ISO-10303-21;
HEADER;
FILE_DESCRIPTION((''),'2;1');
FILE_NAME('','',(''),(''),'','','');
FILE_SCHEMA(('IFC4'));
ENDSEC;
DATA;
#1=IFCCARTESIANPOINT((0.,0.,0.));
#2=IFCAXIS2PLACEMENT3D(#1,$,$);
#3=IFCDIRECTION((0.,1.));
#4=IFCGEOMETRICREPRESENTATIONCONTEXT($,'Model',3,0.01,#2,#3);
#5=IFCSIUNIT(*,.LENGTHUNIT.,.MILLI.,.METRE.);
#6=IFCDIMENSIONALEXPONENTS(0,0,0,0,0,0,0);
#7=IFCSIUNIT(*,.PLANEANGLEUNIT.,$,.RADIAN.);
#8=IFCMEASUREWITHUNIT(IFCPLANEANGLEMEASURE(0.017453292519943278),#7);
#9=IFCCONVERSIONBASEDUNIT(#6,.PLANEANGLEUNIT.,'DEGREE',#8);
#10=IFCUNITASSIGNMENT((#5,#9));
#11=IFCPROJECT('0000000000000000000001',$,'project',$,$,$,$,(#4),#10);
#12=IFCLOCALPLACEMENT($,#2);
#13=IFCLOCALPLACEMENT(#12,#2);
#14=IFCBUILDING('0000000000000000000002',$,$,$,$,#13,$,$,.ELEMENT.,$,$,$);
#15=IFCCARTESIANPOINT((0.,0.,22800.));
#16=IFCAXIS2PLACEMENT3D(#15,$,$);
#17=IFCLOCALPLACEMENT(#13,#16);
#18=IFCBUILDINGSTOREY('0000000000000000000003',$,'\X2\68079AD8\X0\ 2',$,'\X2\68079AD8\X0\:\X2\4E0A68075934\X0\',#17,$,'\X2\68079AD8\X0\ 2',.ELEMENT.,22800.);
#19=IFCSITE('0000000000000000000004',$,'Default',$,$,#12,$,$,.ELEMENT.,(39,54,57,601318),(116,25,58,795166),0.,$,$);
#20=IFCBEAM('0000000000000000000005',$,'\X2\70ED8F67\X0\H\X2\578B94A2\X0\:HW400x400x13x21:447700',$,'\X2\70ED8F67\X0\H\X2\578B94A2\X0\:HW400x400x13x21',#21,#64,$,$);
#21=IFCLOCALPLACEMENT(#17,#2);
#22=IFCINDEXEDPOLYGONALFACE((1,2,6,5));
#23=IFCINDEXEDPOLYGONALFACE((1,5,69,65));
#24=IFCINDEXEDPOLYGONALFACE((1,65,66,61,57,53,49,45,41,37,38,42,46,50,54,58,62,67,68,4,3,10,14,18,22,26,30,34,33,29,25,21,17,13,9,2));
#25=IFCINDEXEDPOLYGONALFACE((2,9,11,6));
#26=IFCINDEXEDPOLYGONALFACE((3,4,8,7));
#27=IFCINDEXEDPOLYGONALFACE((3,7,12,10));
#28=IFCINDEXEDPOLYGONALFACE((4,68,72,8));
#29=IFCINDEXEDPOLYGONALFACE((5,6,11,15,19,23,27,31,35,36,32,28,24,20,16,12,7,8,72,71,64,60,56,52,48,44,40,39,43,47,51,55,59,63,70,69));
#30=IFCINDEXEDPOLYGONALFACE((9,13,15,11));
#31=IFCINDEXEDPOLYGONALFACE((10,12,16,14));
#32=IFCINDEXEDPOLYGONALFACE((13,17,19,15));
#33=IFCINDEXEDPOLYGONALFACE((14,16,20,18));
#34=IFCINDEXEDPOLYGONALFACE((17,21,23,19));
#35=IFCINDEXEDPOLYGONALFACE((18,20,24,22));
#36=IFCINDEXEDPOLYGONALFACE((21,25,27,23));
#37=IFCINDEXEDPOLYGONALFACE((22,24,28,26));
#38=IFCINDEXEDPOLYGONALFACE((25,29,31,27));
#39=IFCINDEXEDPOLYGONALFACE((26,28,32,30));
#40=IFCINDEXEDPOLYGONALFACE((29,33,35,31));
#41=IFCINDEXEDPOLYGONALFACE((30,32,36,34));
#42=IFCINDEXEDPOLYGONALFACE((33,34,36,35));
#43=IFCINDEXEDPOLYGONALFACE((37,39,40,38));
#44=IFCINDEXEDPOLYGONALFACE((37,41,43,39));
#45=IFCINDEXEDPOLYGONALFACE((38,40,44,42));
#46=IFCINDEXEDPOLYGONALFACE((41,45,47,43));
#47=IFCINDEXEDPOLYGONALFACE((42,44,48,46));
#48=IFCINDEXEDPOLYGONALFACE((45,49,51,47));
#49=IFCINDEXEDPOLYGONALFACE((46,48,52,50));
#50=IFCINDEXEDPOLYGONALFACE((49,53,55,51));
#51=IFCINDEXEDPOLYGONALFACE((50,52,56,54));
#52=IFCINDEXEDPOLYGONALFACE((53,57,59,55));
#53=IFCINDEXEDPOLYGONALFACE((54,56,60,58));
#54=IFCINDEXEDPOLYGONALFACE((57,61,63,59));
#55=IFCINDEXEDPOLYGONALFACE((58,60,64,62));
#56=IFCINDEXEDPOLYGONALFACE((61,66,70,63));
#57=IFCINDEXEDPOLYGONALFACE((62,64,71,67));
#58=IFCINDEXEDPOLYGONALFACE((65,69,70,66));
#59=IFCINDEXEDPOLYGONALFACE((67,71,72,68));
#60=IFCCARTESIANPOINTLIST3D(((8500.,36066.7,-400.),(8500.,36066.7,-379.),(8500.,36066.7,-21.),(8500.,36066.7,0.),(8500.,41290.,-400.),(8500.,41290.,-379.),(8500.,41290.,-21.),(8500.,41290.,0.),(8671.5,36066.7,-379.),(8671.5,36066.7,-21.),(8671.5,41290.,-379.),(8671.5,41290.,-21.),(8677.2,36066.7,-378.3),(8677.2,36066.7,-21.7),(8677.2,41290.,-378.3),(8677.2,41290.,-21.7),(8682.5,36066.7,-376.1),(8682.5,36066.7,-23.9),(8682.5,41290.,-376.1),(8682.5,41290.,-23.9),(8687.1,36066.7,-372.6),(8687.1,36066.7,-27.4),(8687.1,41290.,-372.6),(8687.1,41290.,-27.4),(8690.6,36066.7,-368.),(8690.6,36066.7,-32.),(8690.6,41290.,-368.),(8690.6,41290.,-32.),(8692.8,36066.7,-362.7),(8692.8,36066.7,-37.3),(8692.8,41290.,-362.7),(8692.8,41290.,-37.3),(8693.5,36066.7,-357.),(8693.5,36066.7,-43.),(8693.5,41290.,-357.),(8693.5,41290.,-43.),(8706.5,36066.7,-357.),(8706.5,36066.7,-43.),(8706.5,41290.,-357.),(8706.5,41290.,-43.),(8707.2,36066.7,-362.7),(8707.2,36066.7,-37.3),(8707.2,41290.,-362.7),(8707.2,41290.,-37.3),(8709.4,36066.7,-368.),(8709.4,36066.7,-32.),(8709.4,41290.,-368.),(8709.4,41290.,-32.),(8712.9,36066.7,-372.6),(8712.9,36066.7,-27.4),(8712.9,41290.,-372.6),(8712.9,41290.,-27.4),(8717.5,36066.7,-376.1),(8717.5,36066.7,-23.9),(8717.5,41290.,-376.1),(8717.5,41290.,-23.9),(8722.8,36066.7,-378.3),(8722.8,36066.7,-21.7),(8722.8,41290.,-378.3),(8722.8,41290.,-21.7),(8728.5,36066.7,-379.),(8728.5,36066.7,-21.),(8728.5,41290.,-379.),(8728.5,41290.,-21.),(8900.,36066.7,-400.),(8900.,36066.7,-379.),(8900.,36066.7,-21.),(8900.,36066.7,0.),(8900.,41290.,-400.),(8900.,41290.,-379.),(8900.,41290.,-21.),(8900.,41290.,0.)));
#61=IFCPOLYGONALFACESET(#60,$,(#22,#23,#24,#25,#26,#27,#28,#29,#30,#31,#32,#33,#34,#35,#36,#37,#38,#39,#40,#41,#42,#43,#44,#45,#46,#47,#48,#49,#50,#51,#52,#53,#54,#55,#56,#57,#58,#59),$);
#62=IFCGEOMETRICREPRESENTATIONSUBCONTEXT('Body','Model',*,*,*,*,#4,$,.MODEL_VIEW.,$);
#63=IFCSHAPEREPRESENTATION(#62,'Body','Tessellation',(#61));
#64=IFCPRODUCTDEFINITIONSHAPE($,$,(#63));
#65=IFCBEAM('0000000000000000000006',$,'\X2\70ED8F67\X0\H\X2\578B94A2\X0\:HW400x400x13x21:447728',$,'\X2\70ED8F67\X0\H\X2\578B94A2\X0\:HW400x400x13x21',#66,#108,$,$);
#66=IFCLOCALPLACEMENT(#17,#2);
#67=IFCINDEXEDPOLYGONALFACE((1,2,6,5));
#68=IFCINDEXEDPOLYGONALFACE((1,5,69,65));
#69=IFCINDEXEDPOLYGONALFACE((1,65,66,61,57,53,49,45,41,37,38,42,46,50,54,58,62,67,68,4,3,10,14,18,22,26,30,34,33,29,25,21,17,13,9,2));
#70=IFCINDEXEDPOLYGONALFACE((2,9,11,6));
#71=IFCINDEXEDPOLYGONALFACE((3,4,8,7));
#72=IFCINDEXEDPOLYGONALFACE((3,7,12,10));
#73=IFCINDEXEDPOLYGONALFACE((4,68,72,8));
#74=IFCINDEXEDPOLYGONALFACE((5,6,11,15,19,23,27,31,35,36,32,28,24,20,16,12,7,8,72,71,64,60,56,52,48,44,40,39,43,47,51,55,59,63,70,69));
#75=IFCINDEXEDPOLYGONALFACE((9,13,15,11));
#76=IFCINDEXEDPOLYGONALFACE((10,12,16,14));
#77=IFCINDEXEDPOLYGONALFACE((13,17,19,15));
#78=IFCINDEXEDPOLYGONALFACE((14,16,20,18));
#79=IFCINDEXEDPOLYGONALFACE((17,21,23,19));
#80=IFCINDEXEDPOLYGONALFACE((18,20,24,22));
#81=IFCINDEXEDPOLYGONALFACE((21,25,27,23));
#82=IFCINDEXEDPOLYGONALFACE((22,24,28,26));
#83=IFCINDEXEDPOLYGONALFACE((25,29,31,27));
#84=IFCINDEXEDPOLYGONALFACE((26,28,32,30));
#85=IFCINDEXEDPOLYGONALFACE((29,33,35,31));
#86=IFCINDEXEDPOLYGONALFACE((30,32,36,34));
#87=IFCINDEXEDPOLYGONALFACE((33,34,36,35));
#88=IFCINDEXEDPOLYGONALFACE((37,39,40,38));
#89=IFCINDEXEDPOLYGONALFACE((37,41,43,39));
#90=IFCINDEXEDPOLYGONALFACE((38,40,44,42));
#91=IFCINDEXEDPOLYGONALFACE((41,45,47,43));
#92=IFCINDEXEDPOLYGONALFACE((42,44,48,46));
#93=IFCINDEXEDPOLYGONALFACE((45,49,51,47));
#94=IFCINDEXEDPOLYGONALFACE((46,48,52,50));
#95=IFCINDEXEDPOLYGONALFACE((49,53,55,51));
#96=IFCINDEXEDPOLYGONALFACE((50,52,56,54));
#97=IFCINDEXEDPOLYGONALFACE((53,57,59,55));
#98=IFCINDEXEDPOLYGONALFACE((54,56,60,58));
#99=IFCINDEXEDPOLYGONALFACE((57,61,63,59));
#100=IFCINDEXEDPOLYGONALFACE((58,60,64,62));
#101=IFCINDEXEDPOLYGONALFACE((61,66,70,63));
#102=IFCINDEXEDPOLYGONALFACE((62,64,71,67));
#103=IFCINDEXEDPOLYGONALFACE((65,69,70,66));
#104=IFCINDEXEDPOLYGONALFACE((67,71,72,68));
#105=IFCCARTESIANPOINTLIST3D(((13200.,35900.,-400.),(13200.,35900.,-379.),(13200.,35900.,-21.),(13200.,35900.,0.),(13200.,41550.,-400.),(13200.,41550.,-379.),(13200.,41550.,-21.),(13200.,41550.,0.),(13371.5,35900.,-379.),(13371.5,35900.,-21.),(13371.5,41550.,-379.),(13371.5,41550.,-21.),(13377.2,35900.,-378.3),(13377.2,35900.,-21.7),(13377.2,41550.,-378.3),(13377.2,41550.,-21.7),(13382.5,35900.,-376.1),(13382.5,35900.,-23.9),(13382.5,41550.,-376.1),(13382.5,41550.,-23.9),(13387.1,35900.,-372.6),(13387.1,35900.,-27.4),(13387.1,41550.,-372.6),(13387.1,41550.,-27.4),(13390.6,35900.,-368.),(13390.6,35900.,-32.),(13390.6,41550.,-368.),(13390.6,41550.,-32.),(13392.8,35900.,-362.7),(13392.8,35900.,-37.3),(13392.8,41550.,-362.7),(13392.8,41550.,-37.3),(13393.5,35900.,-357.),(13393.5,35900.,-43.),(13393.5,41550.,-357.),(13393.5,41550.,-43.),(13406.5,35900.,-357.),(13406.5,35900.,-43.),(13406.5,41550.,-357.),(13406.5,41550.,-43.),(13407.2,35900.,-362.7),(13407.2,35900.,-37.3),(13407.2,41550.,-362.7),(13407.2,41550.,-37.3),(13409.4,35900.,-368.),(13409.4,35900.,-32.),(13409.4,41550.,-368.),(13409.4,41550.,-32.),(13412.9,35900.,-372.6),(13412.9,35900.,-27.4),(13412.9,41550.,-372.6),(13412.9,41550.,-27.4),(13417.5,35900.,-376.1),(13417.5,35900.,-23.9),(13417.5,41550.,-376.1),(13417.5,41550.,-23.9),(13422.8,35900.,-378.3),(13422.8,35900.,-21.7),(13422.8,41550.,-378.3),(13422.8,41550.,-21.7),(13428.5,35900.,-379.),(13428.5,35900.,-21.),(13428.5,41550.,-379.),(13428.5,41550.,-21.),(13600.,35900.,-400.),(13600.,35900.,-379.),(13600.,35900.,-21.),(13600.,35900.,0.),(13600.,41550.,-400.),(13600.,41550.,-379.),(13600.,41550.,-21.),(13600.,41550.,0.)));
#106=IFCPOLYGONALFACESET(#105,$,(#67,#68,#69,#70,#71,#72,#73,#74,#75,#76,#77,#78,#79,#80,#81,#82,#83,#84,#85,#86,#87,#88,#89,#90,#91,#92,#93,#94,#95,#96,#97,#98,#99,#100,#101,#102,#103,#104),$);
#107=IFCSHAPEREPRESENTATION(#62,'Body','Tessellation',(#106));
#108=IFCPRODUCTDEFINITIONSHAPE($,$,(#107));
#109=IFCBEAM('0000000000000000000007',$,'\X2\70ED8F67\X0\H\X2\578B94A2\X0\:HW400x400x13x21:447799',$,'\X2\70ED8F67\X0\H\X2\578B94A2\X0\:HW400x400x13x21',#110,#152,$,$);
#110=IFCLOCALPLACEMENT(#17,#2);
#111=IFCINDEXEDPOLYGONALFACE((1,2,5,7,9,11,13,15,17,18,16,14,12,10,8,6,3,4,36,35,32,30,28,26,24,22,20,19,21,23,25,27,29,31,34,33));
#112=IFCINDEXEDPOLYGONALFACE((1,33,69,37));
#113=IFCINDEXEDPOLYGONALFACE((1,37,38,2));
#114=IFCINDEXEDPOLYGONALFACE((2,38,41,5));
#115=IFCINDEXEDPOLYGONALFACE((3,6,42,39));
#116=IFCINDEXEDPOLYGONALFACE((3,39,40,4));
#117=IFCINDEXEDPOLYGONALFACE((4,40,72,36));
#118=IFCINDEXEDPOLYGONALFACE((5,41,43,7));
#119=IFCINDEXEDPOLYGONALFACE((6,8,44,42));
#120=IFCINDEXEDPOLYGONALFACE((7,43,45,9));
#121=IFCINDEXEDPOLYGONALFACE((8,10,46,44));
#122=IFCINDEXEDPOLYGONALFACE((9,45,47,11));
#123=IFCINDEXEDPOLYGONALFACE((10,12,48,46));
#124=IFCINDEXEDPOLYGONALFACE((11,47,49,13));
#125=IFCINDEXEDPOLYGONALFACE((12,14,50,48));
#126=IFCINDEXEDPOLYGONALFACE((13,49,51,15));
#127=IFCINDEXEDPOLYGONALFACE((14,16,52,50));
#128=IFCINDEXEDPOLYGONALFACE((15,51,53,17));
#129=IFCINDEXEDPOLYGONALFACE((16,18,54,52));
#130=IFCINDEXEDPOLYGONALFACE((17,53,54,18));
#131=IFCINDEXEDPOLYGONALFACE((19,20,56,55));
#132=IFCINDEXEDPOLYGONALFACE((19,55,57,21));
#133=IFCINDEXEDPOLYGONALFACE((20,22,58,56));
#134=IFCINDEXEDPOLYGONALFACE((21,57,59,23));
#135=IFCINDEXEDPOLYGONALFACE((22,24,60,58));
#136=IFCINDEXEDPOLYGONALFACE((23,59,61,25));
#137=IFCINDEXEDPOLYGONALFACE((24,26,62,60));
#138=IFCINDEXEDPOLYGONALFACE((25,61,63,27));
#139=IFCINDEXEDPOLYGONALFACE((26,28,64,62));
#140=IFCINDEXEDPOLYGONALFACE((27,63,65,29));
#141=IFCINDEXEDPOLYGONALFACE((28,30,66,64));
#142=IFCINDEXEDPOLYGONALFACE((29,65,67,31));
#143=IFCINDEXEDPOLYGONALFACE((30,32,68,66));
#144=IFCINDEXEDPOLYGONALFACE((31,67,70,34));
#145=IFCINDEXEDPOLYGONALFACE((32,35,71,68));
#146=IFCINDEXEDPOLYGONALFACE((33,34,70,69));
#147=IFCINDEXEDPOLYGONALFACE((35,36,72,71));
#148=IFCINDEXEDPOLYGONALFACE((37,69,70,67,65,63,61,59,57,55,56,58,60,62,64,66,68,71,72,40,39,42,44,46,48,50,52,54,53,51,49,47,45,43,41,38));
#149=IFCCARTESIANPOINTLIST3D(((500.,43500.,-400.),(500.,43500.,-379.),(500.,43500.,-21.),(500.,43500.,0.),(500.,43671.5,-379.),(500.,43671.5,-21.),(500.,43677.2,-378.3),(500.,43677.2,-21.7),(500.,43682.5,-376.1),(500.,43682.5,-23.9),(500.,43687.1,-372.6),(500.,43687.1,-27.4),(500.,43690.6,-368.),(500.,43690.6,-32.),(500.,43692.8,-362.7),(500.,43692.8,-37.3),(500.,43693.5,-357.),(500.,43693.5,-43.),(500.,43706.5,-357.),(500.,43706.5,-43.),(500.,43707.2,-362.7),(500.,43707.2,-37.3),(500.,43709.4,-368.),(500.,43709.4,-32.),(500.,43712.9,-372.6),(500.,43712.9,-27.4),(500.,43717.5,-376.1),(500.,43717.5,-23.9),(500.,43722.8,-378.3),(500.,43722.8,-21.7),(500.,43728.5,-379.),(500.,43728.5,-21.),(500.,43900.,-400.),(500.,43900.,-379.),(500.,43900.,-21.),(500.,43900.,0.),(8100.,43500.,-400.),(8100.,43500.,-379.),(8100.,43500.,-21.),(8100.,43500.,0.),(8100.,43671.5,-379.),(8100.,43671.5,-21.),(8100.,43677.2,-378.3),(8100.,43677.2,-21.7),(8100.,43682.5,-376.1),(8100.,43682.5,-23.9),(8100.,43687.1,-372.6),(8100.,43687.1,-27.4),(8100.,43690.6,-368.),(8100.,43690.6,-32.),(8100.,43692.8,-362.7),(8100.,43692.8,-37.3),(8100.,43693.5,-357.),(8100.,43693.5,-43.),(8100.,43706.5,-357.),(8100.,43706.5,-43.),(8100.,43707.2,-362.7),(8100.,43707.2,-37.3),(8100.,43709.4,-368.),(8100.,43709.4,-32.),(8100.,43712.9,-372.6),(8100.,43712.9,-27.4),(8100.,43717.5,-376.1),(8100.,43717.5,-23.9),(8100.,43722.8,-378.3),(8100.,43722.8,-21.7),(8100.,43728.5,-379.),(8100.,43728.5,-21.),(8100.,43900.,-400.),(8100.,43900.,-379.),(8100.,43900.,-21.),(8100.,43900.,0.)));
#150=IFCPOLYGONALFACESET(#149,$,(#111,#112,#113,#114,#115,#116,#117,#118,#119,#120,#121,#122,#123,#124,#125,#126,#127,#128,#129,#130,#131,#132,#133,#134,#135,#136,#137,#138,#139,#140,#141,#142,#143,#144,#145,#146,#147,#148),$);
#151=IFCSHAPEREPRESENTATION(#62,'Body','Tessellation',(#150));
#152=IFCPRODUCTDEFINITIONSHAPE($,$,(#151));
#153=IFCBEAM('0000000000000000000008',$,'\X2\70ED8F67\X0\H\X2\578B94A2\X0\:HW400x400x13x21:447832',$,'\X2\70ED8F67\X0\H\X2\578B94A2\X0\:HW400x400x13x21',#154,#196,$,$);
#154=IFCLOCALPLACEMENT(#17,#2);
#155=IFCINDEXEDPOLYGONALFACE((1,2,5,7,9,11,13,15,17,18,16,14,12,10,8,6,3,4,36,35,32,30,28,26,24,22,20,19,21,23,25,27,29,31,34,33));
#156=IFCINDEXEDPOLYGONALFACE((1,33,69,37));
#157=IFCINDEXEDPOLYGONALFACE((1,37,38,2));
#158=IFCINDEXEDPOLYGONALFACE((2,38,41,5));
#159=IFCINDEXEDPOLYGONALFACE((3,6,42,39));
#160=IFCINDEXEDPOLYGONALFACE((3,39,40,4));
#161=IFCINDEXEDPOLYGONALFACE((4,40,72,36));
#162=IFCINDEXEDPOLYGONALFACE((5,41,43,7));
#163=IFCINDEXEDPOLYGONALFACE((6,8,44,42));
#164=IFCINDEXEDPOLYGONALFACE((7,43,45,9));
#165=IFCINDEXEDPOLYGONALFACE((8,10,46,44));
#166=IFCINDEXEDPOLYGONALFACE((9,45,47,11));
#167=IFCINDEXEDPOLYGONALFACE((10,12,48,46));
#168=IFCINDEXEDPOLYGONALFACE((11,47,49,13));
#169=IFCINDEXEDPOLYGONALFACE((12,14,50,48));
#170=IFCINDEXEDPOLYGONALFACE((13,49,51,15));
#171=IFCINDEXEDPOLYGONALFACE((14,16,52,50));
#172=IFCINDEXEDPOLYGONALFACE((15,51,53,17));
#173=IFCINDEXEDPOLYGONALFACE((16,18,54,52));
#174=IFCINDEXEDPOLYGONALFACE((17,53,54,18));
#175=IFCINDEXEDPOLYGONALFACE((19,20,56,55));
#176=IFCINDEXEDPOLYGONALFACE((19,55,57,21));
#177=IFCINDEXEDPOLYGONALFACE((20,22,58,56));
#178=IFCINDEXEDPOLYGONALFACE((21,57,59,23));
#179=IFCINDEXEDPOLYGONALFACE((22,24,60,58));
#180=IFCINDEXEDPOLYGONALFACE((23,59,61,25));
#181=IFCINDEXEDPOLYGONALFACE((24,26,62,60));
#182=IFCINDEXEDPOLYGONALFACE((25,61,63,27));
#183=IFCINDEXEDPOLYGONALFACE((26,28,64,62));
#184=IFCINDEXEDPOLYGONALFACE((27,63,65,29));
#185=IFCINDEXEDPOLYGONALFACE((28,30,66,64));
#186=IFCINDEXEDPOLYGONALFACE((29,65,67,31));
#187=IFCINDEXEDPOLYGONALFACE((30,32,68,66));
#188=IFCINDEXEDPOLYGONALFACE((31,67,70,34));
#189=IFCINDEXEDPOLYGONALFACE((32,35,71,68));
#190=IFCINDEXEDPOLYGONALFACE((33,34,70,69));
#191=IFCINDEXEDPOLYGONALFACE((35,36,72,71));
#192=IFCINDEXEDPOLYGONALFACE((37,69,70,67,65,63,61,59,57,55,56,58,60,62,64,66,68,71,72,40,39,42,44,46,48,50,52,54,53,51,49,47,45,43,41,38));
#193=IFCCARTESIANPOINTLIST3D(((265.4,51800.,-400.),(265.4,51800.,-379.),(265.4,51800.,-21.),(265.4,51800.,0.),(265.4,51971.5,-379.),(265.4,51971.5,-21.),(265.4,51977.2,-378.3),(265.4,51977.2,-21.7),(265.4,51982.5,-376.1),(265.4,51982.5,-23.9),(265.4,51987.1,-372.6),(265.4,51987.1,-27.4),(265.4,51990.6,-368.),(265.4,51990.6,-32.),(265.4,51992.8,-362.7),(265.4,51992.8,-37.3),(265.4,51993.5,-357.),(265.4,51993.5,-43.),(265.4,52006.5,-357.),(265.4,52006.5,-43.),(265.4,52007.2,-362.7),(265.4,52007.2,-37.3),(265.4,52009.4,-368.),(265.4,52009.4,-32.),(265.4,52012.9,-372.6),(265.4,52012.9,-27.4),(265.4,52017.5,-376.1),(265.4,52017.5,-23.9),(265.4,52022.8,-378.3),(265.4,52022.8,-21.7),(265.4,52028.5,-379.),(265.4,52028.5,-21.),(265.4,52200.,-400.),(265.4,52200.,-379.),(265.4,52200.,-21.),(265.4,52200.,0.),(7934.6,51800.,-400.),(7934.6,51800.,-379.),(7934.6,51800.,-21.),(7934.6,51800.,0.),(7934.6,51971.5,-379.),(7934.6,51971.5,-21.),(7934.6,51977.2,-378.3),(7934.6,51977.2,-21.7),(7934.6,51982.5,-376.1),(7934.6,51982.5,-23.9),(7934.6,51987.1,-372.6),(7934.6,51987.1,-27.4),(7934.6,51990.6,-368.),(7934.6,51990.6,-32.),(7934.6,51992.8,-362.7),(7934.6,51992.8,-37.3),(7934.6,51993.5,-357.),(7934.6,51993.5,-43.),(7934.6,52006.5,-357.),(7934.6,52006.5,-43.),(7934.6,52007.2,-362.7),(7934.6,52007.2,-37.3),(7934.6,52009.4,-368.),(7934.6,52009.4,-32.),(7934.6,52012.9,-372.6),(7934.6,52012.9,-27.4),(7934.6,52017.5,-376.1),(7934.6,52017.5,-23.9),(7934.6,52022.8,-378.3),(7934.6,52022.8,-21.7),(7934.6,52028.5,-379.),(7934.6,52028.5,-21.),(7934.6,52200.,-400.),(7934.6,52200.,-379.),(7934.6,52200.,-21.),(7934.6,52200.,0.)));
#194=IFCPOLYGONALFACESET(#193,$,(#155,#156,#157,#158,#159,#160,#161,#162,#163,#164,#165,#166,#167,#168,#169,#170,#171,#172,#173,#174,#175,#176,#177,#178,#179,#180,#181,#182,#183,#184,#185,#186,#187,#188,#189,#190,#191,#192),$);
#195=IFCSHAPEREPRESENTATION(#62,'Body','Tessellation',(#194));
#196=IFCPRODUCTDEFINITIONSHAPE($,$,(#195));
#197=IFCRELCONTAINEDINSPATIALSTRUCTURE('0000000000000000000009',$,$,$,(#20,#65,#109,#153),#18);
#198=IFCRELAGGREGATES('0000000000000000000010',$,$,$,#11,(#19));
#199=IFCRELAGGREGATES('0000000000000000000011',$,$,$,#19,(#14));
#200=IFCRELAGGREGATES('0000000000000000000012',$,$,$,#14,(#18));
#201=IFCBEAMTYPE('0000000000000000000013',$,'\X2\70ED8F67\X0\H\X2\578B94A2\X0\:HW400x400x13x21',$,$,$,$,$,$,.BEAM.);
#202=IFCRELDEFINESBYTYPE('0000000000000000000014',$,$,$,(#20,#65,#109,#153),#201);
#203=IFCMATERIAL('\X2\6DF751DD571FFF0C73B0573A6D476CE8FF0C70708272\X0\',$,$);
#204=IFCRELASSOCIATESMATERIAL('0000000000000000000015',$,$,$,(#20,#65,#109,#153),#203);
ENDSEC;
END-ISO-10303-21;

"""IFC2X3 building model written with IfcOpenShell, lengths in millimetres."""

from ifc_helpers import new_model, entity, si_unit, converted_unit, direction, frame, frame_2d, origin, place, context, subcontext, project, spatial, i_section, extrude, material, type_object, element, save


model = new_model("IFC2X3")

# Units and contexts
model_context = context("Model", 3, precision=0.01, world=origin(), true_north=direction((0.0, 1.0)))
body_context = subcontext(model_context, "Body", "Model", "MODEL_VIEW")
ifc_project = project(units=[si_unit("LENGTHUNIT", "METRE", prefix="MILLI"), converted_unit("PLANEANGLEUNIT", "DEGREE", entity("IfcPlaneAngleMeasure", 0.017453292519943278), si_unit("PLANEANGLEUNIT", "RADIAN"), dimensions=[0, 0, 0, 0, 0, 0, 0])], contexts=[model_context])

# Site, building, storey
site_placement = place(None, origin())
site = spatial("IfcSite", under=ifc_project, at=site_placement, Name="Default", CompositionType="ELEMENT", RefLatitude=(39, 54, 57, 601318), RefLongitude=(116, 25, 58, 795166), RefElevation=0.0)
building_placement = place(site_placement, origin())
building = spatial("IfcBuilding", under=site, at=building_placement, CompositionType="ELEMENT")
storey_placement = place(building_placement, frame((0.0, 0.0, 22800.0)))
storey = spatial("IfcBuildingStorey", under=building, at=storey_placement, Name="标高 2", ObjectType="标高:上标头", LongName="标高 2", CompositionType="ELEMENT", Elevation=22800.0)

# Beams
ifc_material = material(Name="混凝土，现场浇注，灰色")
beam_type = type_object("IfcBeamType", Name="热轧H型钢:HW400x400x13x21", PredefinedType="BEAM")
beam_1_placement = place(storey_placement, frame((8700.0, 35900.0, 0.0), z_axis=(0.0, 0.0, 1.0), x_axis=(0.0, 1.0, 0.0)))
element("IfcBeam", 1, at=beam_1_placement, inside=storey, type_object=beam_type, material=ifc_material, Name="热轧H型钢:HW400x400x13x21:447700", ObjectType="热轧H型钢:HW400x400x13x21", context=body_context, shape_type="SweptSolid", body=[
    extrude(i_section(OverallWidth=400.0, OverallDepth=400.0, WebThickness=13.0, FlangeThickness=21.0, FilletRadius=22.0, at=frame_2d((0.0, 0.0), x_axis=(0.0, 1.0))), frame((166.7, 0.0, -200.0), z_axis=(1.0, 0.0, 0.0), x_axis=(0.0, 0.0, -1.0)), (0.0, 0.0, 1.0), 5223.3),
])
beam_2_placement = place(storey_placement, frame((13400.0, 41550.0, 0.0), z_axis=(0.0, 0.0, 1.0), x_axis=(0.0, -1.0, 0.0)))
element("IfcBeam", 2, at=beam_2_placement, inside=storey, type_object=beam_type, material=ifc_material, Name="热轧H型钢:HW400x400x13x21:447728", ObjectType="热轧H型钢:HW400x400x13x21", context=body_context, shape_type="SweptSolid", body=[
    extrude(i_section(OverallWidth=400.0, OverallDepth=400.0, WebThickness=13.0, FlangeThickness=21.0, FilletRadius=22.0, at=frame_2d((0.0, 0.0), x_axis=(0.0, 1.0))), frame((0.0, 0.0, -200.0), z_axis=(1.0, 0.0, 0.0), x_axis=(0.0, 0.0, -1.0)), (0.0, 0.0, 1.0), 5650.0),
])
beam_3_placement = place(storey_placement, frame((500.0, 43700.0, 0.0)))
element("IfcBeam", 3, at=beam_3_placement, inside=storey, type_object=beam_type, material=ifc_material, Name="热轧H型钢:HW400x400x13x21:447799", ObjectType="热轧H型钢:HW400x400x13x21", context=body_context, shape_type="SweptSolid", body=[
    extrude(i_section(OverallWidth=400.0, OverallDepth=400.0, WebThickness=13.0, FlangeThickness=21.0, FilletRadius=22.0, at=frame_2d((0.0, 0.0), x_axis=(0.0, 1.0))), frame((0.0, 0.0, -200.0), z_axis=(1.0, 0.0, 0.0), x_axis=(0.0, 0.0, -1.0)), (0.0, 0.0, 1.0), 7600.0),
])
beam_4_placement = place(storey_placement, frame((8100.0, 52000.0, 0.0), z_axis=(0.0, 0.0, 1.0), x_axis=(-1.0, 0.0, 0.0)))
element("IfcBeam", 4, at=beam_4_placement, inside=storey, type_object=beam_type, material=ifc_material, Name="热轧H型钢:HW400x400x13x21:447832", ObjectType="热轧H型钢:HW400x400x13x21", context=body_context, shape_type="SweptSolid", body=[
    extrude(i_section(OverallWidth=400.0, OverallDepth=400.0, WebThickness=13.0, FlangeThickness=21.0, FilletRadius=22.0, at=frame_2d((0.0, 0.0), x_axis=(0.0, 1.0))), frame((165.4, 0.0, -200.0), z_axis=(1.0, 0.0, 0.0), x_axis=(0.0, 0.0, -1.0)), (0.0, 0.0, 1.0), 7669.2),
])

save(model, "model.ifc")
